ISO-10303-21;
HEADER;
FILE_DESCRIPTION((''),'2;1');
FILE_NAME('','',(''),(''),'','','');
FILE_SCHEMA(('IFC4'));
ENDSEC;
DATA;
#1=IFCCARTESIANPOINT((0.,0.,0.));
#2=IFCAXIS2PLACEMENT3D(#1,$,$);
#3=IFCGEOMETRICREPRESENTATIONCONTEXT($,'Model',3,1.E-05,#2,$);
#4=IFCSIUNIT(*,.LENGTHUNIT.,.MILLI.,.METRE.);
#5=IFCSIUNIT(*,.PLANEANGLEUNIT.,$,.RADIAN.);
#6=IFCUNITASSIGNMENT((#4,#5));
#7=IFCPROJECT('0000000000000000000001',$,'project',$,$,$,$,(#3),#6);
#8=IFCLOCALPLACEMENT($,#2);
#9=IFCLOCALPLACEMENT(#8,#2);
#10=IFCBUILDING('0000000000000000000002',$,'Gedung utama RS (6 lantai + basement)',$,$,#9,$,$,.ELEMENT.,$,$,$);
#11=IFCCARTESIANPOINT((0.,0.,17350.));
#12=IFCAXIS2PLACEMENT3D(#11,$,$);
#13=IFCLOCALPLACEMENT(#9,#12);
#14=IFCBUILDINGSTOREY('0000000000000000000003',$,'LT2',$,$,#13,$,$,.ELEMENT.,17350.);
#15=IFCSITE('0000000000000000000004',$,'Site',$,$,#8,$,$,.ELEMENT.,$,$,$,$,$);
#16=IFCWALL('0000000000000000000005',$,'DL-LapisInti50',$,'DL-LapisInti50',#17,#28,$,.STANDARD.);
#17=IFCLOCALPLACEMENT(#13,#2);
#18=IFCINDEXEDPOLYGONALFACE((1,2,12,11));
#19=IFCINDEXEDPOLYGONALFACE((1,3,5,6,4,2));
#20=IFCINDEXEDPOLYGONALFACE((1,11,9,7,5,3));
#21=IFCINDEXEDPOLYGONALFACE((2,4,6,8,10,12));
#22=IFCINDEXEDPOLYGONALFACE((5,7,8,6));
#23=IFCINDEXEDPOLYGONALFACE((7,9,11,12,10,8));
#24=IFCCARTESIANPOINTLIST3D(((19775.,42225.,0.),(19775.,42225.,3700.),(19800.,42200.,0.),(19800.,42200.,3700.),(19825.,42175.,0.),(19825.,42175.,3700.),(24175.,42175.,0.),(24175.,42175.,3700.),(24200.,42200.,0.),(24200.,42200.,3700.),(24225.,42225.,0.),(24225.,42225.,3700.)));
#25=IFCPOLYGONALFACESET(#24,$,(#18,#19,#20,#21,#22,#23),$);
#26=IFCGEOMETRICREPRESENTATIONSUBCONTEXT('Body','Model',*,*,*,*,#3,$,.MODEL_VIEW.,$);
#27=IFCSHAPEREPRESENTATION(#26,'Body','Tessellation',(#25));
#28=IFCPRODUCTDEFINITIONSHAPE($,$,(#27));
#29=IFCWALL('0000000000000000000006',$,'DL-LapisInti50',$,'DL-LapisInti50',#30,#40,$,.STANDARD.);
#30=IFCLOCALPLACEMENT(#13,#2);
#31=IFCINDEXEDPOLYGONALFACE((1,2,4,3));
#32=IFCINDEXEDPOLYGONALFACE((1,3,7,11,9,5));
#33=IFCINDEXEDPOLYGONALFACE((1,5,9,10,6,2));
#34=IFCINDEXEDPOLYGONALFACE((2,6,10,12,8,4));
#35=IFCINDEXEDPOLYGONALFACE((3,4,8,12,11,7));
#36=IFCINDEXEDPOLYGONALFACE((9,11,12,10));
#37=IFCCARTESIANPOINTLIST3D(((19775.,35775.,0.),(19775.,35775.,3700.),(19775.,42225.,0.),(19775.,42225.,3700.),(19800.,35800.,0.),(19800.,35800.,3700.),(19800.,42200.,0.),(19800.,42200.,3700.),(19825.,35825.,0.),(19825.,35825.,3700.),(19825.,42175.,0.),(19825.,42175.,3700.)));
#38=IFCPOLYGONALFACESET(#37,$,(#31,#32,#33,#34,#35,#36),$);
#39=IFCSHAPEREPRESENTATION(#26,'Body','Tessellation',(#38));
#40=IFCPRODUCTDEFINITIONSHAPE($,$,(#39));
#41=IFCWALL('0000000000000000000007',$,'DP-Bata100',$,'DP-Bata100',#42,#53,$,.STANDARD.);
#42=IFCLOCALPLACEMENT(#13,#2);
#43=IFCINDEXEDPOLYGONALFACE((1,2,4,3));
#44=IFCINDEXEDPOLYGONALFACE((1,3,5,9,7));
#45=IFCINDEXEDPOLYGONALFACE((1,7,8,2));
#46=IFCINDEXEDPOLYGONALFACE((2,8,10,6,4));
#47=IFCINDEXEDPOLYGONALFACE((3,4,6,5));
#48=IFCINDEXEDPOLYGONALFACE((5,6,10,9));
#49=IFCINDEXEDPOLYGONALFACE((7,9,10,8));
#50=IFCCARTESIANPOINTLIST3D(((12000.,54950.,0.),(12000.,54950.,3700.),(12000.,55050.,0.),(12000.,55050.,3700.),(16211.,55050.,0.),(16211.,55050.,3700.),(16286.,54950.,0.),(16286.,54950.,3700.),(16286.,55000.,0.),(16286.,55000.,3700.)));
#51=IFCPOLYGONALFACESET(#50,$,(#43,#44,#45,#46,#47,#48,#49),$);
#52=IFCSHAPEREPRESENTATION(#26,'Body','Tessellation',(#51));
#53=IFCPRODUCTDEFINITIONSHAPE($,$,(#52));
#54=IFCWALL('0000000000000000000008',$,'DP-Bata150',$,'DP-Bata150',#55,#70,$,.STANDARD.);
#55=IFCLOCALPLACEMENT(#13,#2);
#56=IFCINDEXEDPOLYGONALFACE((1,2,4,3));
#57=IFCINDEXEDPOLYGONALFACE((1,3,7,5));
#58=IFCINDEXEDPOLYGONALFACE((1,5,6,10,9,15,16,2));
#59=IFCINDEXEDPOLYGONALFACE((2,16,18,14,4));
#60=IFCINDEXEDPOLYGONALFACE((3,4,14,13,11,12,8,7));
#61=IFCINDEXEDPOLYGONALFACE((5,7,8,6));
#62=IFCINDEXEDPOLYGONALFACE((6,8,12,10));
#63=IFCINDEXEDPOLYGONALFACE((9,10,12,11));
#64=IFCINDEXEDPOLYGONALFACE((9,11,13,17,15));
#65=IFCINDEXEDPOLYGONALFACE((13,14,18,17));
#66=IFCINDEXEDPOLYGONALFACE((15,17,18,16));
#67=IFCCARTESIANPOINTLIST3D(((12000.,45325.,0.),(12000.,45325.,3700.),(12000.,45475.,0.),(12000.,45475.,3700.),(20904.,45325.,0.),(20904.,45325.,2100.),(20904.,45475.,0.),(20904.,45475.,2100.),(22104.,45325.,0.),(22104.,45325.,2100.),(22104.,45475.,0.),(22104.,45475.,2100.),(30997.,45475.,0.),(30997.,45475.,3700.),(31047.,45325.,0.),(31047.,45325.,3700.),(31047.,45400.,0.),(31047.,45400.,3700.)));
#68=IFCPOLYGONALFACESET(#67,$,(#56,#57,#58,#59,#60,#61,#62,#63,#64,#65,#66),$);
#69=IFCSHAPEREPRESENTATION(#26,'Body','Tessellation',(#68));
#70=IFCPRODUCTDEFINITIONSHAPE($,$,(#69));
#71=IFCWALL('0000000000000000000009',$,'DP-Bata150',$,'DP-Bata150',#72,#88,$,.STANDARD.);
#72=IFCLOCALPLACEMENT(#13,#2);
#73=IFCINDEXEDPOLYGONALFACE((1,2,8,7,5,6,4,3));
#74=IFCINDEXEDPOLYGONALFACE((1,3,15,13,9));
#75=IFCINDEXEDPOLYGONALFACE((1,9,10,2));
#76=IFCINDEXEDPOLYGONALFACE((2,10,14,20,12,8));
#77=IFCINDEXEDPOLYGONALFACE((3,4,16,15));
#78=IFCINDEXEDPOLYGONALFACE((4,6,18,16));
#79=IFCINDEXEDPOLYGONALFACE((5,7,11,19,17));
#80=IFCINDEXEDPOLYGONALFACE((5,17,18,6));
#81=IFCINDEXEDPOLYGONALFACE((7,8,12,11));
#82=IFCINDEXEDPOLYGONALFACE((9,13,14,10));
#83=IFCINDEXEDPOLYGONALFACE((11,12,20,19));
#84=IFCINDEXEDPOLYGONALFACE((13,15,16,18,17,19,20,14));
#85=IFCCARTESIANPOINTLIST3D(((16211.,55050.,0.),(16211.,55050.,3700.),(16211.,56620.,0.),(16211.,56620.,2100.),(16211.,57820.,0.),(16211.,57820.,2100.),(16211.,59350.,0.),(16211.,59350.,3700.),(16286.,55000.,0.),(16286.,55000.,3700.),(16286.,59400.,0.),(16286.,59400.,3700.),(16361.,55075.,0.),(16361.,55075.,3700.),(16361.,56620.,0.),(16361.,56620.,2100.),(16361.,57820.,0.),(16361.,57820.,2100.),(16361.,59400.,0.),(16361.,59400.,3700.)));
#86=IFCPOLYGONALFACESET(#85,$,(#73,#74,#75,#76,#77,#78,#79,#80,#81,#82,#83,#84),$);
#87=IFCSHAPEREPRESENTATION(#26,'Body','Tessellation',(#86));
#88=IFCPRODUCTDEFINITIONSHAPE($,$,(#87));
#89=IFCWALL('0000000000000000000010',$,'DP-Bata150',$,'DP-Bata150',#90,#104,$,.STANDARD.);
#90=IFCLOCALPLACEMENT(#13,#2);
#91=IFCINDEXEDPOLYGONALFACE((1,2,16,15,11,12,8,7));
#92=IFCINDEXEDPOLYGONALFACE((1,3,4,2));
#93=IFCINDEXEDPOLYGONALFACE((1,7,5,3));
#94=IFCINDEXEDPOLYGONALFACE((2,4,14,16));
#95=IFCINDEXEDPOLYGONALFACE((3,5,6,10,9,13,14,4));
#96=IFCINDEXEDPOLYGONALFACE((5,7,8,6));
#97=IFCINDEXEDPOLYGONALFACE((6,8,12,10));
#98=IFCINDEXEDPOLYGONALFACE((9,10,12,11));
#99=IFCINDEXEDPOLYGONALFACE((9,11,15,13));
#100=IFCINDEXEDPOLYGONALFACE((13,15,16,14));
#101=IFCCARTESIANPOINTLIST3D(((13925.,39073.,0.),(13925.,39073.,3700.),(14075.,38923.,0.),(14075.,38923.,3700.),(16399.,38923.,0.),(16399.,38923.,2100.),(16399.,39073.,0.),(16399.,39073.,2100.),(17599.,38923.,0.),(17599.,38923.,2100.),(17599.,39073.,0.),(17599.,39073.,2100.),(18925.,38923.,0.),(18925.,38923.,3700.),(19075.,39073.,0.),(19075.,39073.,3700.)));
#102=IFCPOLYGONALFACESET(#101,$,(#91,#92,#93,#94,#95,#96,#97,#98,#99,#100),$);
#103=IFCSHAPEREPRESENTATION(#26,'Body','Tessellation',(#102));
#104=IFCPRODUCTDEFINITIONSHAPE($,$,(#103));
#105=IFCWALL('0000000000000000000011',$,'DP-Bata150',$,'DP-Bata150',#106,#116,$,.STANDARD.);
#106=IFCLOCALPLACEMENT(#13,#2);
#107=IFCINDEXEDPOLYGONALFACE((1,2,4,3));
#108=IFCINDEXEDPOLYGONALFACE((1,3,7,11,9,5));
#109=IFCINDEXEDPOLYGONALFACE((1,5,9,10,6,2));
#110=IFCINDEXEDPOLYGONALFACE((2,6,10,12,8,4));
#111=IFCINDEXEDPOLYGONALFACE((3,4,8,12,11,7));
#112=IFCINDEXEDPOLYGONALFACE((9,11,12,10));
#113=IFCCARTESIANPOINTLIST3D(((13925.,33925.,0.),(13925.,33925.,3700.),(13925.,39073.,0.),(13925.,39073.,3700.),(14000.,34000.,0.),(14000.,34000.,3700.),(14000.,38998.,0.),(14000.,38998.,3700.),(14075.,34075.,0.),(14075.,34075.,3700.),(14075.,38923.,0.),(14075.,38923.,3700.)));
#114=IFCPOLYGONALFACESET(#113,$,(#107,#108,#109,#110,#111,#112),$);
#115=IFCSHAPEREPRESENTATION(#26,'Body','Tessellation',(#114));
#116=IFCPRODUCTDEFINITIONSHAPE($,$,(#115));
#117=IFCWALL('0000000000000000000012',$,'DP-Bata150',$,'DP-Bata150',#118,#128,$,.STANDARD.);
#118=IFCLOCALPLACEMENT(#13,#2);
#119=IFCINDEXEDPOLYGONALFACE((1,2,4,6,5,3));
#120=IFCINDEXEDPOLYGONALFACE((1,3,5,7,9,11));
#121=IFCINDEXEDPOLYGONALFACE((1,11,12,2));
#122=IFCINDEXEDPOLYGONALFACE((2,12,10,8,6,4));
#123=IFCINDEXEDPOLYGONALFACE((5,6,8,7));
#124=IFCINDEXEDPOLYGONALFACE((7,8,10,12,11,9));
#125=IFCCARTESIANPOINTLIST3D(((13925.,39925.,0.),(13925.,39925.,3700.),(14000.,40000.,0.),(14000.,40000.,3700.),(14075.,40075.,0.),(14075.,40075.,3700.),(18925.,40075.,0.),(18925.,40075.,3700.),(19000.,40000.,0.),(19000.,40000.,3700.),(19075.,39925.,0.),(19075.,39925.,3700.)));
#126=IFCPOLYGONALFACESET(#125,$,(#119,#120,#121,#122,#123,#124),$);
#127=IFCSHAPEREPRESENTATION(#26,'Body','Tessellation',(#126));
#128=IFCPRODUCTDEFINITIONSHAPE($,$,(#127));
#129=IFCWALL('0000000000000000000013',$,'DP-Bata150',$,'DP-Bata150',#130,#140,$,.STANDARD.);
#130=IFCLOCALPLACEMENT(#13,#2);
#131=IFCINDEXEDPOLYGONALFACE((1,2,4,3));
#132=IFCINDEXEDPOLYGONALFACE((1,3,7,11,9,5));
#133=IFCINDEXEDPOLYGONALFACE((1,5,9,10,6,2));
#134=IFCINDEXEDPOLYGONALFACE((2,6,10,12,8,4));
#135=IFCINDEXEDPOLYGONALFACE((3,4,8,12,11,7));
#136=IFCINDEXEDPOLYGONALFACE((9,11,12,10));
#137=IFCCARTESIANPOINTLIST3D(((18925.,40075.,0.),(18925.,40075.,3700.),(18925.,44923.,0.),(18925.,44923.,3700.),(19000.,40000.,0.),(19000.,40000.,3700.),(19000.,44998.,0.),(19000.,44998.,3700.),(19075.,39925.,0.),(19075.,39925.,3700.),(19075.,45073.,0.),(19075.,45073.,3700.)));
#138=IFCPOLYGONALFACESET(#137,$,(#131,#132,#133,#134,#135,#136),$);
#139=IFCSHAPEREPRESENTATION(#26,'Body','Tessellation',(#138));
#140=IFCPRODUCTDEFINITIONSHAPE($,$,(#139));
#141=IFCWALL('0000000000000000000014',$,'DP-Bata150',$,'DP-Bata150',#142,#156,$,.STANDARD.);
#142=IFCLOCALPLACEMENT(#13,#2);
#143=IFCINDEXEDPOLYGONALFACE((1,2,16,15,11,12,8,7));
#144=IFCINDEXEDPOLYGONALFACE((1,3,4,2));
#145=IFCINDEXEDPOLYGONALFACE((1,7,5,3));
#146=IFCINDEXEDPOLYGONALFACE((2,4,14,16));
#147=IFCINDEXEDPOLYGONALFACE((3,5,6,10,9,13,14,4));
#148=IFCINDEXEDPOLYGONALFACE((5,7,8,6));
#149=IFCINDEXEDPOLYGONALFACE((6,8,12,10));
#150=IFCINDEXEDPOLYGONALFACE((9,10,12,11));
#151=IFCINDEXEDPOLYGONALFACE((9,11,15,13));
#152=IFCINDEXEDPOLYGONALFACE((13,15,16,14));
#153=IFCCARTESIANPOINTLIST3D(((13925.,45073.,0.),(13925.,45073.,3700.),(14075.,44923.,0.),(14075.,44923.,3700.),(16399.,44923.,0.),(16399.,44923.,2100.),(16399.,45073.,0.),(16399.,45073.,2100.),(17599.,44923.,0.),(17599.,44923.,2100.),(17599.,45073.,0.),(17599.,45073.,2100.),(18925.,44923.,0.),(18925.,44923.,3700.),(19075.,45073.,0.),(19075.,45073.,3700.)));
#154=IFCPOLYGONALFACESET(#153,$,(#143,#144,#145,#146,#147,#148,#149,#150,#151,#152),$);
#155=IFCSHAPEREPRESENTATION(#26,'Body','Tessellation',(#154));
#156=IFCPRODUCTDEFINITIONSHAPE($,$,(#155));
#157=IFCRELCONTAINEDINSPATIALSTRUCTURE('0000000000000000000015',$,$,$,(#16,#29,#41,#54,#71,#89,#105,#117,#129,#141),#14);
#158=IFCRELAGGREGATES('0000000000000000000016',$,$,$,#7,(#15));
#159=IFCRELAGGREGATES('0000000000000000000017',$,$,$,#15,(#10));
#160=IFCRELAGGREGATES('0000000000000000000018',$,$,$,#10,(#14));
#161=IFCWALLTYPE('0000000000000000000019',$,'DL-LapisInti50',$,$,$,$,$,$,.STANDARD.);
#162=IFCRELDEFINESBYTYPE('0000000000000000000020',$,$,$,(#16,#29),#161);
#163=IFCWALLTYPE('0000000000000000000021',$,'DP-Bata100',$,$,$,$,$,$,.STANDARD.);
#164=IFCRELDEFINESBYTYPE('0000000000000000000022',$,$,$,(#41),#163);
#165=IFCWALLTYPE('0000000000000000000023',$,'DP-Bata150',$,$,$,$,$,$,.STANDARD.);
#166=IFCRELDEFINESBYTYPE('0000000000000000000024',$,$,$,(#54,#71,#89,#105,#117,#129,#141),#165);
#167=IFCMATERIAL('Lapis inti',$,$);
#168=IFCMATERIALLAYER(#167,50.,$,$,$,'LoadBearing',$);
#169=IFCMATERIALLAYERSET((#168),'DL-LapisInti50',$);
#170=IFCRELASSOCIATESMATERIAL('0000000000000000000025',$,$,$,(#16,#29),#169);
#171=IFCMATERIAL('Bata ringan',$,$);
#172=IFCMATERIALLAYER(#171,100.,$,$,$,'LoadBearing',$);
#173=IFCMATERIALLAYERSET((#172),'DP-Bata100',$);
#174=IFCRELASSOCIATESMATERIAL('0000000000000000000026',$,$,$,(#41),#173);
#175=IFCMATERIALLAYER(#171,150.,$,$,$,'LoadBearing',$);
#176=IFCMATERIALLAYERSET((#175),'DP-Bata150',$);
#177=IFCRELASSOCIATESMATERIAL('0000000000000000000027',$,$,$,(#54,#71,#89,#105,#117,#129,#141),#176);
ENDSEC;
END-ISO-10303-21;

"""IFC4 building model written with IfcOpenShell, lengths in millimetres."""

from ifc_helpers import new_model, si_unit, frame, frame_2d, origin, place, context, subcontext, project, spatial, polyline, rectangle, outline, extrude, material, layer, layer_set, layer_usage, type_object, element, save


model = new_model("IFC4")

# Units and contexts
model_context = context("Model", 3, precision=1e-05, world=origin())
body_context = subcontext(model_context, "Body", "Model", "MODEL_VIEW")
ifc_project = project(units=[si_unit("LENGTHUNIT", "METRE", prefix="MILLI"), si_unit("PLANEANGLEUNIT", "RADIAN")], contexts=[model_context])

# Site, building, storey
site_placement = place(None, origin())
site = spatial("IfcSite", under=ifc_project, at=site_placement, Name="Site", CompositionType="ELEMENT")
building_placement = place(site_placement, origin())
building = spatial("IfcBuilding", under=site, at=building_placement, Name="Gedung utama RS (6 lantai + basement)", CompositionType="ELEMENT")
storey_placement = place(building_placement, frame((0.0, 0.0, 17350.0)))
storey = spatial("IfcBuildingStorey", under=building, at=storey_placement, Name="LT2", CompositionType="ELEMENT", Elevation=17350.0)

# Walls
ifc_material_1 = material(Name="Lapis inti")
ifc_layer_1 = layer(ifc_material_1, 50.0, Category="LoadBearing")
ifc_layer_set_1 = layer_set([ifc_layer_1], Name="DL-LapisInti50")
ifc_layer_usage_1 = layer_usage(ifc_layer_set_1, "AXIS2", "NEGATIVE", 25.0)
wall_type_1 = type_object("IfcWallType", Name="DL-LapisInti50", PredefinedType="STANDARD")
wall_1_placement = place(storey_placement, frame((24200.0, 42200.0, 0.0), z_axis=(0.0, 0.0, 1.0), x_axis=(-1.0, 0.0, 0.0)))
element("IfcWall", 1, at=wall_1_placement, inside=storey, type_object=wall_type_1, material=ifc_layer_usage_1, Name="DL-LapisInti50", ObjectType="DL-LapisInti50", PredefinedType="STANDARD", context=body_context, shape_type="SweptSolid", body=[
    extrude(outline(polyline([(-25.0, -25.0), (0.0, 0.0), (25.0, 25.0), (4375.0, 25.0), (4400.0, 0.0), (4425.0, -25.0), (-25.0, -25.0)])), origin(), (0.0, 0.0, 1.0), 3700.0),
])
wall_2_placement = place(storey_placement, frame((19800.0, 42200.0, 0.0), z_axis=(0.0, 0.0, 1.0), x_axis=(0.0, -1.0, 0.0)))
element("IfcWall", 2, at=wall_2_placement, inside=storey, type_object=wall_type_1, material=ifc_layer_usage_1, Name="DL-LapisInti50", ObjectType="DL-LapisInti50", PredefinedType="STANDARD", context=body_context, shape_type="SweptSolid", body=[
    extrude(outline(polyline([(-25.0, -25.0), (0.0, 0.0), (25.0, 25.0), (6375.0, 25.0), (6400.0, 0.0), (6425.0, -25.0), (-25.0, -25.0)])), origin(), (0.0, 0.0, 1.0), 3700.0),
])
ifc_material_2 = material(Name="Bata ringan")
ifc_layer_2 = layer(ifc_material_2, 100.0, Category="LoadBearing")
ifc_layer_set_2 = layer_set([ifc_layer_2], Name="DP-Bata100")
ifc_layer_usage_2 = layer_usage(ifc_layer_set_2, "AXIS2", "NEGATIVE", 50.0)
wall_type_2 = type_object("IfcWallType", Name="DP-Bata100", PredefinedType="STANDARD")
wall_3_placement = place(storey_placement, frame((16286.0, 55000.0, 0.0), z_axis=(0.0, 0.0, 1.0), x_axis=(-1.0, 0.0, 0.0)))
element("IfcWall", 3, at=wall_3_placement, inside=storey, type_object=wall_type_2, material=ifc_layer_usage_2, Name="DP-Bata100", ObjectType="DP-Bata100", PredefinedType="STANDARD", context=body_context, shape_type="SweptSolid", body=[
    extrude(outline(polyline([(75.0, -50.0), (0.0, 0.0), (0.0, 50.0), (4286.0, 50.0), (4286.0, -50.0), (75.0, -50.0)])), origin(), (0.0, 0.0, 1.0), 3700.0),
])

# Walls, openings
ifc_layer_3 = layer(ifc_material_2, 150.0, Category="LoadBearing")
ifc_layer_set_3 = layer_set([ifc_layer_3], Name="DP-Bata150")
ifc_layer_usage_3 = layer_usage(ifc_layer_set_3, "AXIS2", "NEGATIVE", 75.0)
wall_type_3 = type_object("IfcWallType", Name="DP-Bata150", PredefinedType="STANDARD")
wall_4_placement = place(storey_placement, frame((12000.0, 45400.0, 0.0), z_axis=(0.0, 0.0, 1.0), x_axis=(1.0, 0.0, 0.0)))
wall_4 = element("IfcWall", 4, at=wall_4_placement, inside=storey, type_object=wall_type_3, material=ifc_layer_usage_3, Name="DP-Bata150", ObjectType="DP-Bata150", PredefinedType="STANDARD", context=body_context, shape_type="SweptSolid", body=[
    extrude(outline(polyline([(0.0, -75.0), (0.0, 75.0), (18997.0, 75.0), (19047.0, 0.0), (19047.0, -75.0), (0.0, -75.0)])), origin(), (0.0, 0.0, 1.0), 3700.0),
])
opening_1_placement = place(wall_4_placement, frame((8904.0, 0.0, 0.0), z_axis=(0.0, 0.0, 1.0), x_axis=(1.0, 0.0, 0.0)))
element("IfcOpeningElement", 5, at=opening_1_placement, cuts=wall_4, PredefinedType="OPENING", context=body_context, shape_type="SweptSolid", body=[
    extrude(rectangle(XDim=1200.0, YDim=170.0, at=frame_2d((600.0, 0.0))), origin(), (0.0, 0.0, 1.0), 2100.0),
])
wall_5_placement = place(storey_placement, frame((16286.0, 55000.0, 0.0), z_axis=(0.0, 0.0, 1.0), x_axis=(0.0, 1.0, 0.0)))
wall_5 = element("IfcWall", 6, at=wall_5_placement, inside=storey, type_object=wall_type_3, material=ifc_layer_usage_3, Name="DP-Bata150", ObjectType="DP-Bata150", PredefinedType="STANDARD", context=body_context, shape_type="SweptSolid", body=[
    extrude(outline(polyline([(75.0, -75.0), (0.0, 0.0), (50.0, 75.0), (4350.0, 75.0), (4400.0, 0.0), (4400.0, -75.0), (75.0, -75.0)])), origin(), (0.0, 0.0, 1.0), 3700.0),
])
opening_2_placement = place(wall_5_placement, frame((1620.0, 0.0, 0.0), z_axis=(0.0, 0.0, 1.0), x_axis=(1.0, 0.0, 0.0)))
element("IfcOpeningElement", 7, at=opening_2_placement, cuts=wall_5, PredefinedType="OPENING", context=body_context, shape_type="SweptSolid", body=[
    extrude(rectangle(XDim=1200.0, YDim=170.0, at=frame_2d((600.0, 0.0))), origin(), (0.0, 0.0, 1.0), 2100.0),
])
wall_6_placement = place(storey_placement, frame((19000.0, 38998.0, 0.0), z_axis=(0.0, 0.0, 1.0), x_axis=(-1.0, 0.0, 0.0)))
wall_6 = element("IfcWall", 8, at=wall_6_placement, inside=storey, type_object=wall_type_3, material=ifc_layer_usage_3, Name="DP-Bata150", ObjectType="DP-Bata150", PredefinedType="STANDARD", context=body_context, shape_type="SweptSolid", body=[
    extrude(outline(polyline([(-75.0, -75.0), (0.0, 0.0), (75.0, 75.0), (4925.0, 75.0), (5000.0, 0.0), (5075.0, -75.0), (-75.0, -75.0)])), origin(), (0.0, 0.0, 1.0), 3700.0),
])
opening_3_placement = place(wall_6_placement, frame((1401.0, 0.0, 0.0), z_axis=(0.0, 0.0, 1.0), x_axis=(1.0, 0.0, 0.0)))
element("IfcOpeningElement", 9, at=opening_3_placement, cuts=wall_6, PredefinedType="OPENING", context=body_context, shape_type="SweptSolid", body=[
    extrude(rectangle(XDim=1200.0, YDim=170.0, at=frame_2d((600.0, 0.0))), origin(), (0.0, 0.0, 1.0), 2100.0),
])

# Walls
wall_7_placement = place(storey_placement, frame((14000.0, 38998.0, 0.0), z_axis=(0.0, 0.0, 1.0), x_axis=(0.0, -1.0, 0.0)))
element("IfcWall", 10, at=wall_7_placement, inside=storey, type_object=wall_type_3, material=ifc_layer_usage_3, Name="DP-Bata150", ObjectType="DP-Bata150", PredefinedType="STANDARD", context=body_context, shape_type="SweptSolid", body=[
    extrude(outline(polyline([(-75.0, -75.0), (0.0, 0.0), (75.0, 75.0), (4923.0, 75.0), (4998.0, 0.0), (5073.0, -75.0), (-75.0, -75.0)])), origin(), (0.0, 0.0, 1.0), 3700.0),
])
wall_8_placement = place(storey_placement, frame((14000.0, 40000.0, 0.0), z_axis=(0.0, 0.0, 1.0), x_axis=(1.0, 0.0, 0.0)))
element("IfcWall", 11, at=wall_8_placement, inside=storey, type_object=wall_type_3, material=ifc_layer_usage_3, Name="DP-Bata150", ObjectType="DP-Bata150", PredefinedType="STANDARD", context=body_context, shape_type="SweptSolid", body=[
    extrude(outline(polyline([(-75.0, -75.0), (0.0, 0.0), (75.0, 75.0), (4925.0, 75.0), (5000.0, 0.0), (5075.0, -75.0), (-75.0, -75.0)])), origin(), (0.0, 0.0, 1.0), 3700.0),
])
wall_9_placement = place(storey_placement, frame((19000.0, 40000.0, 0.0), z_axis=(0.0, 0.0, 1.0), x_axis=(0.0, 1.0, 0.0)))
element("IfcWall", 12, at=wall_9_placement, inside=storey, type_object=wall_type_3, material=ifc_layer_usage_3, Name="DP-Bata150", ObjectType="DP-Bata150", PredefinedType="STANDARD", context=body_context, shape_type="SweptSolid", body=[
    extrude(outline(polyline([(-75.0, -75.0), (0.0, 0.0), (75.0, 75.0), (4923.0, 75.0), (4998.0, 0.0), (5073.0, -75.0), (-75.0, -75.0)])), origin(), (0.0, 0.0, 1.0), 3700.0),
])

# Wall, opening
wall_10_placement = place(storey_placement, frame((19000.0, 44998.0, 0.0), z_axis=(0.0, 0.0, 1.0), x_axis=(-1.0, 0.0, 0.0)))
wall_10 = element("IfcWall", 13, at=wall_10_placement, inside=storey, type_object=wall_type_3, material=ifc_layer_usage_3, Name="DP-Bata150", ObjectType="DP-Bata150", PredefinedType="STANDARD", context=body_context, shape_type="SweptSolid", body=[
    extrude(outline(polyline([(-75.0, -75.0), (0.0, 0.0), (75.0, 75.0), (4925.0, 75.0), (5000.0, 0.0), (5075.0, -75.0), (-75.0, -75.0)])), origin(), (0.0, 0.0, 1.0), 3700.0),
])
opening_4_placement = place(wall_10_placement, frame((1401.0, 0.0, 0.0), z_axis=(0.0, 0.0, 1.0), x_axis=(1.0, 0.0, 0.0)))
element("IfcOpeningElement", 14, at=opening_4_placement, cuts=wall_10, PredefinedType="OPENING", context=body_context, shape_type="SweptSolid", body=[
    extrude(rectangle(XDim=1200.0, YDim=170.0, at=frame_2d((600.0, 0.0))), origin(), (0.0, 0.0, 1.0), 2100.0),
])

save(model, "model.ifc")
